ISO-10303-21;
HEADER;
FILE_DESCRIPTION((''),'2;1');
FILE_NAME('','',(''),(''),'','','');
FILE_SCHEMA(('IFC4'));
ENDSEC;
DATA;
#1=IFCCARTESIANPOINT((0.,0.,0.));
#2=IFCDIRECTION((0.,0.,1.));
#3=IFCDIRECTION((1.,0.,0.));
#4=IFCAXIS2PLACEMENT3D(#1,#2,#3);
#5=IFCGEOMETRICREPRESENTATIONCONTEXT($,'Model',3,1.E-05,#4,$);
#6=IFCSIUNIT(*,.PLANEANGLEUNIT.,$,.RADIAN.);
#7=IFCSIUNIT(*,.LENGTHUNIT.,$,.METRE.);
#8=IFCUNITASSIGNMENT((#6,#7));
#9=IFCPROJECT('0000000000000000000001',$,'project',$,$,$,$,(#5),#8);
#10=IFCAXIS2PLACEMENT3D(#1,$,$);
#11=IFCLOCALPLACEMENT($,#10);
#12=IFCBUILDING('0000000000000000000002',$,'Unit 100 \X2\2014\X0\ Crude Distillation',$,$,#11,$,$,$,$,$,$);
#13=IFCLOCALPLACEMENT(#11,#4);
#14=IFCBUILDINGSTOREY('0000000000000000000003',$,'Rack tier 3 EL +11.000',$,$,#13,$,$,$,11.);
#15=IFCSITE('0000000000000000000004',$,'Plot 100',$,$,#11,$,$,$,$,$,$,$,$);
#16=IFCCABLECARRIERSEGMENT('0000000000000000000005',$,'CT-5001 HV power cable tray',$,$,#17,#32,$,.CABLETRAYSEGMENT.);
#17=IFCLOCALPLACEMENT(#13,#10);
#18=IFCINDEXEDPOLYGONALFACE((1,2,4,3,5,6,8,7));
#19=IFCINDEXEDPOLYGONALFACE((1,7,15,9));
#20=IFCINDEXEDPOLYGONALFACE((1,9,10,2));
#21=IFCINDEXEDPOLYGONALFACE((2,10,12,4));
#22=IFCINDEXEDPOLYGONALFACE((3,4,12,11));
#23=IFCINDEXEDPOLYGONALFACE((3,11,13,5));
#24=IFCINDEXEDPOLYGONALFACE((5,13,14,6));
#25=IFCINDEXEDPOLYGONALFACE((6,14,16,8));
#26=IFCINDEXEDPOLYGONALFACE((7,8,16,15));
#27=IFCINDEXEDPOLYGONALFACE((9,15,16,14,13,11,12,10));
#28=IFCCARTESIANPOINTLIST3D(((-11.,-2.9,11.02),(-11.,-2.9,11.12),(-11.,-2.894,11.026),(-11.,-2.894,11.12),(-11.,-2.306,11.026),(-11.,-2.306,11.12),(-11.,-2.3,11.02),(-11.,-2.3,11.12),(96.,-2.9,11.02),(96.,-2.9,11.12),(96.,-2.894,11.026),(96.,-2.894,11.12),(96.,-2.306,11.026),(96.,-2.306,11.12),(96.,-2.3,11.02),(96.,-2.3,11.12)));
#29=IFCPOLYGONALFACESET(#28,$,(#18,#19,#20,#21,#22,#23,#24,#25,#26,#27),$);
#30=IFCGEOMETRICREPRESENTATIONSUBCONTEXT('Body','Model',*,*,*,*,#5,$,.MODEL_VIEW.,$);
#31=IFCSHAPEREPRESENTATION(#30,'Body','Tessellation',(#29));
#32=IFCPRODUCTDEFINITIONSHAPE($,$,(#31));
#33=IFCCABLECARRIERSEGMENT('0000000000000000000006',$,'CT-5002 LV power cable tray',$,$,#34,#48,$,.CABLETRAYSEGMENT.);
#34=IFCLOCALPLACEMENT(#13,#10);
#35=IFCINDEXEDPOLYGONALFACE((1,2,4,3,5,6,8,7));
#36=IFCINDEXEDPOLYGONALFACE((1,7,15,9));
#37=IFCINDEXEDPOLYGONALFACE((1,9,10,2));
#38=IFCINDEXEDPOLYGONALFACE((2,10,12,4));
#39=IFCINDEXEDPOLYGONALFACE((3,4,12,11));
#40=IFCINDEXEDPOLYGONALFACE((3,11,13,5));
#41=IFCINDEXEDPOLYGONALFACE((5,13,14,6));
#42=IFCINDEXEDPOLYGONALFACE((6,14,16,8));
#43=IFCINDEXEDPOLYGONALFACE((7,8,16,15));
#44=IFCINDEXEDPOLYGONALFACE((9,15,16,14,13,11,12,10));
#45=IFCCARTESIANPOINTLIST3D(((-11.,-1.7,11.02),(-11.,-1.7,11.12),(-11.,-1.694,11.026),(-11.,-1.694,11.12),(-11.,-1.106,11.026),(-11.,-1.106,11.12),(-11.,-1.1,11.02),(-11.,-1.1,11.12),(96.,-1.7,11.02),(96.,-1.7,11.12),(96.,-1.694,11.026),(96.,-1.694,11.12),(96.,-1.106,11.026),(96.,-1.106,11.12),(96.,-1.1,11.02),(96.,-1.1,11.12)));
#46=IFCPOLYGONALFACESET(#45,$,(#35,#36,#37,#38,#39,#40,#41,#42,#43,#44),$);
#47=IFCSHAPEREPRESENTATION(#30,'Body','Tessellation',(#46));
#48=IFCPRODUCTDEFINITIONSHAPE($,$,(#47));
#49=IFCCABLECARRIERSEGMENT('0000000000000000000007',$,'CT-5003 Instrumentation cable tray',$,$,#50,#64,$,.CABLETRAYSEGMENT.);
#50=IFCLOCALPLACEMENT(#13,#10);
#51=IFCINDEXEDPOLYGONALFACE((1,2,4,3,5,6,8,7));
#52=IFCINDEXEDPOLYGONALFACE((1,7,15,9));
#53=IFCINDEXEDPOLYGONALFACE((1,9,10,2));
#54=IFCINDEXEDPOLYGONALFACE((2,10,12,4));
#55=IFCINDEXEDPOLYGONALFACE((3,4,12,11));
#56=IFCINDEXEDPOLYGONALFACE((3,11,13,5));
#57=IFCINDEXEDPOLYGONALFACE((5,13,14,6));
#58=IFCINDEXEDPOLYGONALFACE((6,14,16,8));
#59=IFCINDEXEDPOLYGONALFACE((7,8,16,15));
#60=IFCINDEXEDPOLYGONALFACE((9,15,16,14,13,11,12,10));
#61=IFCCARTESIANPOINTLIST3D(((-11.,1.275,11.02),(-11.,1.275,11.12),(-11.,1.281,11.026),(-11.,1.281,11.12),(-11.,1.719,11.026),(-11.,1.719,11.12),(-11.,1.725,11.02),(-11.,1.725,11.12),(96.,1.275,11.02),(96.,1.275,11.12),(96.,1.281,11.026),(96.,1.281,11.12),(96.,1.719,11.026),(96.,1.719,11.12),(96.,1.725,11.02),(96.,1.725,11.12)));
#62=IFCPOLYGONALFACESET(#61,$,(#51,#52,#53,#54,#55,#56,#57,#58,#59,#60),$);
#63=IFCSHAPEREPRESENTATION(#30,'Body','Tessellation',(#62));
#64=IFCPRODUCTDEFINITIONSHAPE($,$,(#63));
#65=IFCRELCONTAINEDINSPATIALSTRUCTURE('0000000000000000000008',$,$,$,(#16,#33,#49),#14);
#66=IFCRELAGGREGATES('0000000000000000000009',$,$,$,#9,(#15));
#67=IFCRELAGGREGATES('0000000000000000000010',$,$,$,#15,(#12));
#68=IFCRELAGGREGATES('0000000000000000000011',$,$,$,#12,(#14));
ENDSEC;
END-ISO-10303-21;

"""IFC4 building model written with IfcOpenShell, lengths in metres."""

from ifc_helpers import new_model, si_unit, frame, frame_2d, origin, origin_with_axes, place, context, subcontext, project, spatial, u_section, extrude, element, save


model = new_model("IFC4")

# Units and contexts
model_context = context("Model", 3, precision=1e-05, world=origin_with_axes())
body_context = subcontext(model_context, "Body", "Model", "MODEL_VIEW")
ifc_project = project(units=[si_unit("PLANEANGLEUNIT", "RADIAN"), si_unit("LENGTHUNIT", "METRE")], contexts=[model_context])

# Site, building, storey
placement = place(None, origin())
site = spatial("IfcSite", under=ifc_project, at=placement, Name="Plot 100")
building = spatial("IfcBuilding", under=site, at=placement, Name="Unit 100 — Crude Distillation")
storey_placement = place(placement, origin_with_axes())
storey = spatial("IfcBuildingStorey", under=building, at=storey_placement, Name="Rack tier 3 EL +11.000", Elevation=11.0)

# Cable carrier segments
cable_carrier_segment_1_placement = place(storey_placement, origin_with_axes())
element("IfcCableCarrierSegment", 1, at=cable_carrier_segment_1_placement, inside=storey, Name="CT-5001 HV power cable tray", PredefinedType="CABLETRAYSEGMENT", context=body_context, shape_type="SweptSolid", body=[
    extrude(u_section(Depth=0.6, FlangeWidth=0.1, WebThickness=0.006, FlangeThickness=0.006, at=frame_2d((0.0, 0.0), x_axis=(0.0, 1.0))), frame((-11.0, -2.6, 11.07), z_axis=(1.0, 0.0, 0.0), x_axis=(0.0, 1.0, 0.0)), (0.0, 0.0, 1.0), 107.0),
])
cable_carrier_segment_2_placement = place(storey_placement, origin_with_axes())
element("IfcCableCarrierSegment", 2, at=cable_carrier_segment_2_placement, inside=storey, Name="CT-5002 LV power cable tray", PredefinedType="CABLETRAYSEGMENT", context=body_context, shape_type="SweptSolid", body=[
    extrude(u_section(Depth=0.6, FlangeWidth=0.1, WebThickness=0.006, FlangeThickness=0.006, at=frame_2d((0.0, 0.0), x_axis=(0.0, 1.0))), frame((-11.0, -1.4, 11.07), z_axis=(1.0, 0.0, 0.0), x_axis=(0.0, 1.0, 0.0)), (0.0, 0.0, 1.0), 107.0),
])
cable_carrier_segment_3_placement = place(storey_placement, origin_with_axes())
element("IfcCableCarrierSegment", 3, at=cable_carrier_segment_3_placement, inside=storey, Name="CT-5003 Instrumentation cable tray", PredefinedType="CABLETRAYSEGMENT", context=body_context, shape_type="SweptSolid", body=[
    extrude(u_section(Depth=0.45, FlangeWidth=0.1, WebThickness=0.006, FlangeThickness=0.006, at=frame_2d((0.0, 0.0), x_axis=(0.0, 1.0))), frame((-11.0, 1.5, 11.07), z_axis=(1.0, 0.0, 0.0), x_axis=(0.0, 1.0, 0.0)), (0.0, 0.0, 1.0), 107.0),
])

save(model, "model.ifc")
